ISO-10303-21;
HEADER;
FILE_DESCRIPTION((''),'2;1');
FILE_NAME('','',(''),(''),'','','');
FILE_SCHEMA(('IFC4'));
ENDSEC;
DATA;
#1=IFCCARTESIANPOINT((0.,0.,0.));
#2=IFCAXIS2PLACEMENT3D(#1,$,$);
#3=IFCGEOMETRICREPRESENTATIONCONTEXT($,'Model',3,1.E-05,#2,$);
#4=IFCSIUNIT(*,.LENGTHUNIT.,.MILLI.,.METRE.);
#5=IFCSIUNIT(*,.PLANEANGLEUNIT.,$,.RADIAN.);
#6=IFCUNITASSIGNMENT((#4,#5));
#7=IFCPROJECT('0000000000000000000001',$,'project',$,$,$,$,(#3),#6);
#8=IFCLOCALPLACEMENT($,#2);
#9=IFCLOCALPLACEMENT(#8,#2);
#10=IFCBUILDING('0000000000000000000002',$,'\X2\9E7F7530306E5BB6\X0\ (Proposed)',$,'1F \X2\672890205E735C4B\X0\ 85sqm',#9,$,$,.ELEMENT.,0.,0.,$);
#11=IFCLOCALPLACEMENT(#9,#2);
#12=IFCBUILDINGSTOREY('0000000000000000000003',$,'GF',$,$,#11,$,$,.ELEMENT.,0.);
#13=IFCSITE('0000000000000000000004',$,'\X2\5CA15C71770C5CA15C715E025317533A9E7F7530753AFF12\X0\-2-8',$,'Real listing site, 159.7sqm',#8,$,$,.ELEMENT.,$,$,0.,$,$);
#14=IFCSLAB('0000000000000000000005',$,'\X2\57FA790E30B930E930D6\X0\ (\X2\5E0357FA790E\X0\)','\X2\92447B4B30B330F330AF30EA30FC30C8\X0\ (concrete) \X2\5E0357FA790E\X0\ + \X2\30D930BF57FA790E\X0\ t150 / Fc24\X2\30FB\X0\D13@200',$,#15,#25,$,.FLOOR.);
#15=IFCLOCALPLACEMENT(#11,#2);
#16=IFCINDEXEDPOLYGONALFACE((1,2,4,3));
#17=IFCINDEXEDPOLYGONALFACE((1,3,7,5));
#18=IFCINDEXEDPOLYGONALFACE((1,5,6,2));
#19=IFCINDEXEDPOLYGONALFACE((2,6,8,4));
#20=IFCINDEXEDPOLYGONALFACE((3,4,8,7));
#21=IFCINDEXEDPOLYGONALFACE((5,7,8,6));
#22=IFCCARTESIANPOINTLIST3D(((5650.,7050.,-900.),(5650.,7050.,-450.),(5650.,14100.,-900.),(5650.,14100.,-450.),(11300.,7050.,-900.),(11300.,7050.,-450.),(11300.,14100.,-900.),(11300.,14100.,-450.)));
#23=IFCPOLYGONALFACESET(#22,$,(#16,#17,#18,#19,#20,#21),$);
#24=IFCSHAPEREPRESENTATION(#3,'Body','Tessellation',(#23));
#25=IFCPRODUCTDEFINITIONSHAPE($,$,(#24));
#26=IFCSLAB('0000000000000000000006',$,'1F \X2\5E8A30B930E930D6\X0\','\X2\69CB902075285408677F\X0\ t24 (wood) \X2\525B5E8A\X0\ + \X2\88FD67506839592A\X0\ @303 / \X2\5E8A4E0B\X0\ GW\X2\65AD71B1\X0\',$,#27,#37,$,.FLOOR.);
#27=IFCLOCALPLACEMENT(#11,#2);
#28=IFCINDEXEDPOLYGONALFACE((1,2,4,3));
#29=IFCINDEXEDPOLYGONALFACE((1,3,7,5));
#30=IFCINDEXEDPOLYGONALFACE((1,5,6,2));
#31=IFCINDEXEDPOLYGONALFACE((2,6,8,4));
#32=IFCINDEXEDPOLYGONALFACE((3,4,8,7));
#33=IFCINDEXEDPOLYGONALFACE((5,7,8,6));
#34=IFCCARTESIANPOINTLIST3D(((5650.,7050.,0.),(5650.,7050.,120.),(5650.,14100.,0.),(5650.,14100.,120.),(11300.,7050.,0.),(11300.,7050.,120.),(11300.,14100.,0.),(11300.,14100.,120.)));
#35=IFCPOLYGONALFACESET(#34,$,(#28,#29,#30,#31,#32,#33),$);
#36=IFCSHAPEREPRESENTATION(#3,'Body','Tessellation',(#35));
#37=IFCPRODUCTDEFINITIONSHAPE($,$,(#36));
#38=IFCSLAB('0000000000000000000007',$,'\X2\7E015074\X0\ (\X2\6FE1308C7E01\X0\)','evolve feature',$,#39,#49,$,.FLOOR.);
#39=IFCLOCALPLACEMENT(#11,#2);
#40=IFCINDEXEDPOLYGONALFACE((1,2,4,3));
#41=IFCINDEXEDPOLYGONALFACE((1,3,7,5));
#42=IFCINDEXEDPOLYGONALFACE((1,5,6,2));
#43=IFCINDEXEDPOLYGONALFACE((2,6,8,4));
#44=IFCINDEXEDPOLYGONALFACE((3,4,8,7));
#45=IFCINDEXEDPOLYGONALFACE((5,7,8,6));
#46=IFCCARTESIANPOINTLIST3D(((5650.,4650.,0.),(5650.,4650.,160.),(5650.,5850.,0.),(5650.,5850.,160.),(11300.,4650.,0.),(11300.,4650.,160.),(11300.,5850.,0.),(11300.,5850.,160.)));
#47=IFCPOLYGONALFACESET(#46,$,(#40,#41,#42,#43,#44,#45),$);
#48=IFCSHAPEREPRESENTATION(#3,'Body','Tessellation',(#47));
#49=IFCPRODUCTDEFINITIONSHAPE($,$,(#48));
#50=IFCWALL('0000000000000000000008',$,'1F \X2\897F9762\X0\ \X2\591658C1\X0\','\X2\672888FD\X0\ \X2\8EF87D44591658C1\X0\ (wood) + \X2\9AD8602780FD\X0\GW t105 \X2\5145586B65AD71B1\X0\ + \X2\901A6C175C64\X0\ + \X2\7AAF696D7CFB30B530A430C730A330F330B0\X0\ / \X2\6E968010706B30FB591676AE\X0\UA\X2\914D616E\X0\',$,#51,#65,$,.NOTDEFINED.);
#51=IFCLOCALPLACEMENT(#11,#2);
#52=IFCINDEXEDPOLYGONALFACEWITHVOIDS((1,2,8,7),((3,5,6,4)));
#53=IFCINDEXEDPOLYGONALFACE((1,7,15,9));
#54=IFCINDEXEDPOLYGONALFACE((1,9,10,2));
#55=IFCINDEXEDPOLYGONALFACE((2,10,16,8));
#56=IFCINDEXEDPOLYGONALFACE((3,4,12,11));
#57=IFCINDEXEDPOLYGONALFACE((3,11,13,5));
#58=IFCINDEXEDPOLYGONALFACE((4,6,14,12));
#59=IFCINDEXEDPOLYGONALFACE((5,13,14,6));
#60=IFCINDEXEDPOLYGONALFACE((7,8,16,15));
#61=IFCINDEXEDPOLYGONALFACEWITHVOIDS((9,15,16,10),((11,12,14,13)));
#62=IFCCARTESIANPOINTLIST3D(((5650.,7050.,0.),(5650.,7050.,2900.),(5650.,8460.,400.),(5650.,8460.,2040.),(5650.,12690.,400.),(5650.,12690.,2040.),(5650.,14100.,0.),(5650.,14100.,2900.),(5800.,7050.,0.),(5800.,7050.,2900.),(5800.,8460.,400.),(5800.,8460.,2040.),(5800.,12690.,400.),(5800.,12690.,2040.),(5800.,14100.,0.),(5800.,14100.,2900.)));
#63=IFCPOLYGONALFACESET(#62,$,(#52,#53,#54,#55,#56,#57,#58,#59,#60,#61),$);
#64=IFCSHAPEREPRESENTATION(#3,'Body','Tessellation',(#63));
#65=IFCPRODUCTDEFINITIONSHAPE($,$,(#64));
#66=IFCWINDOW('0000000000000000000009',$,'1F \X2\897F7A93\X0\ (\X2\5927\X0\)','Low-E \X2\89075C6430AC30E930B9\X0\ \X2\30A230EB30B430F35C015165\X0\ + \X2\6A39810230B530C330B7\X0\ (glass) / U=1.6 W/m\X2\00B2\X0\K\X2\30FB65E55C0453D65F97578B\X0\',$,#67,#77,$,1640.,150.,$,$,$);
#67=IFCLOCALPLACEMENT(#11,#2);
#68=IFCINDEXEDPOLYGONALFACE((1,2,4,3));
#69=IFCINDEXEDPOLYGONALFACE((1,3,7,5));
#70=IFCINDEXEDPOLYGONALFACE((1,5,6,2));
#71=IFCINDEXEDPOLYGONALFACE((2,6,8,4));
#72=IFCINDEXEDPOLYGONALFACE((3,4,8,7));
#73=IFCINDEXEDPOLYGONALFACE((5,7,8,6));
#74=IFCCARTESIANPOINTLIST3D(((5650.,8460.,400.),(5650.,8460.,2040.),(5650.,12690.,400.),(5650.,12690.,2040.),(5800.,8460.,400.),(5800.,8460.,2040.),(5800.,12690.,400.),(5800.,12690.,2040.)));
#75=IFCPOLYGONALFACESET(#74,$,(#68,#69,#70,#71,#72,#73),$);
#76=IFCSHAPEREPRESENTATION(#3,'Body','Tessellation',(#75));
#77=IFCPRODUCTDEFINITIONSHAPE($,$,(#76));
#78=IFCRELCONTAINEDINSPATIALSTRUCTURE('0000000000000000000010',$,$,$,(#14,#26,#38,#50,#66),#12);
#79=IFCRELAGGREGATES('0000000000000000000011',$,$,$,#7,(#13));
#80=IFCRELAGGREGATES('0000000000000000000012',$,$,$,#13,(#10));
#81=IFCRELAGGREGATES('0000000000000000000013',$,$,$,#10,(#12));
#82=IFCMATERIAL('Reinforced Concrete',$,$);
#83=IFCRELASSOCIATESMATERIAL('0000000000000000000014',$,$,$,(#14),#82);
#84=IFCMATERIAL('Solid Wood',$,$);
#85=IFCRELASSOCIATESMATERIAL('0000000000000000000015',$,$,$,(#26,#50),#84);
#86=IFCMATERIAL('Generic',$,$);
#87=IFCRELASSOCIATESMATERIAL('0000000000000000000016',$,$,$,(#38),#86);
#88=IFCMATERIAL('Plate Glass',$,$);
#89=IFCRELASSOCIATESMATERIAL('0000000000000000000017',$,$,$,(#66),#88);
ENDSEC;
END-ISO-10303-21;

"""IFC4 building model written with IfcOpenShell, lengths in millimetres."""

from ifc_helpers import new_model, si_unit, frame, frame_2d, origin, place, context, project, spatial, rectangle, extrude, material, element, fill, save


model = new_model("IFC4")

# Units and contexts
model_context = context("Model", 3, precision=1e-05, world=origin())
ifc_project = project(units=[si_unit("LENGTHUNIT", "METRE", prefix="MILLI"), si_unit("PLANEANGLEUNIT", "RADIAN")], contexts=[model_context])

# Site, building, storey
site_placement = place(None, origin())
site = spatial("IfcSite", under=ifc_project, at=site_placement, Name="岡山県岡山市北区鹿田町２-2-8", ObjectType="Real listing site, 159.7sqm", CompositionType="ELEMENT", RefElevation=0.0)
building_placement = place(site_placement, origin())
building = spatial("IfcBuilding", under=site, at=building_placement, Name="鹿田の家 (Proposed)", ObjectType="1F 木造平屋 85sqm", CompositionType="ELEMENT", ElevationOfRefHeight=0.0, ElevationOfTerrain=0.0)
storey_placement = place(building_placement, origin())
storey = spatial("IfcBuildingStorey", under=building, at=storey_placement, Name="GF", CompositionType="ELEMENT", Elevation=0.0)

# Slabs
ifc_material_1 = material(Name="Reinforced Concrete")
slab_1_placement = place(storey_placement, frame((2825.0, 3525.0, -450.0)))
element("IfcSlab", 1, at=slab_1_placement, inside=storey, material=ifc_material_1, Name="基礎スラブ (布基礎)", Description="鉄筋コンクリート (concrete) 布基礎 + ベタ基礎 t150 / Fc24・D13@200", PredefinedType="FLOOR", context=model_context, shape_type="SweptSolid", body=[
    extrude(rectangle(XDim=5650.0, YDim=7050.0, at=frame_2d((2825.0, 3525.0))), frame((2825.0, 3525.0, -450.0)), (0.0, 0.0, 1.0), 450.0),
])
ifc_material_2 = material(Name="Solid Wood")
slab_2_placement = place(storey_placement, frame((2825.0, 3525.0, 0.0)))
element("IfcSlab", 2, at=slab_2_placement, inside=storey, material=ifc_material_2, Name="1F 床スラブ", Description="構造用合板 t24 (wood) 剛床 + 製材根太 @303 / 床下 GW断熱", PredefinedType="FLOOR", context=model_context, shape_type="SweptSolid", body=[
    extrude(rectangle(XDim=5650.0, YDim=7050.0, at=frame_2d((2825.0, 3525.0))), frame((2825.0, 3525.0, 0.0)), (0.0, 0.0, 1.0), 120.0),
])
ifc_material_3 = material(Name="Generic")
slab_3_placement = place(storey_placement, frame((2825.0, 2325.0, 0.0)))
element("IfcSlab", 3, at=slab_3_placement, inside=storey, material=ifc_material_3, Name="縁側 (濡れ縁)", Description="evolve feature", PredefinedType="FLOOR", context=model_context, shape_type="SweptSolid", body=[
    extrude(rectangle(XDim=5650.0, YDim=1200.0, at=frame_2d((2825.0, 600.0))), frame((2825.0, 2325.0, 0.0)), (0.0, 0.0, 1.0), 160.0),
])

# Shared definitions
ifc_material_4 = material(Name="Plate Glass")

# Wall, opening, window
wall_1_placement = place(storey_placement, frame((2825.0, 3525.0, 0.0)))
wall_1 = element("IfcWall", 4, at=wall_1_placement, inside=storey, material=ifc_material_2, Name="1F 西面 外壁", Description="木製 軸組外壁 (wood) + 高性能GW t105 充填断熱 + 通気層 + 窯業系サイディング / 準耐火・外皮UA配慮", PredefinedType="NOTDEFINED", context=model_context, shape_type="SweptSolid", body=[
    extrude(rectangle(XDim=150.0, YDim=7050.0, at=frame_2d((75.0, 3525.0))), frame((2825.0, 3525.0, 0.0)), (0.0, 0.0, 1.0), 2900.0),
])
opening_1_placement = place(storey_placement, frame((2825.0, 4230.0, 200.0)))
opening_1 = element("IfcOpeningElement", 5, at=opening_1_placement, cuts=wall_1, PredefinedType="NOTDEFINED", context=model_context, shape_type="SweptSolid", body=[
    extrude(rectangle(XDim=150.0, YDim=4230.0, at=frame_2d((75.0, 2115.0))), frame((2825.0, 4230.0, 200.0)), (0.0, 0.0, 1.0), 1640.0),
])
window_1_placement = place(storey_placement, frame((2825.0, 4230.0, 200.0)))
window_1 = element("IfcWindow", 6, at=window_1_placement, inside=storey, material=ifc_material_4, Name="1F 西窓 (大)", Description="Low-E 複層ガラス アルゴン封入 + 樹脂サッシ (glass) / U=1.6 W/m²K・日射取得型", OverallHeight=1640.0, OverallWidth=150.0, context=model_context, shape_type="SweptSolid", body=[
    extrude(rectangle(XDim=150.0, YDim=4230.0, at=frame_2d((75.0, 2115.0))), frame((2825.0, 4230.0, 200.0)), (0.0, 0.0, 1.0), 1640.0),
])
fill(opening_1, window_1)

save(model, "model.ifc")
